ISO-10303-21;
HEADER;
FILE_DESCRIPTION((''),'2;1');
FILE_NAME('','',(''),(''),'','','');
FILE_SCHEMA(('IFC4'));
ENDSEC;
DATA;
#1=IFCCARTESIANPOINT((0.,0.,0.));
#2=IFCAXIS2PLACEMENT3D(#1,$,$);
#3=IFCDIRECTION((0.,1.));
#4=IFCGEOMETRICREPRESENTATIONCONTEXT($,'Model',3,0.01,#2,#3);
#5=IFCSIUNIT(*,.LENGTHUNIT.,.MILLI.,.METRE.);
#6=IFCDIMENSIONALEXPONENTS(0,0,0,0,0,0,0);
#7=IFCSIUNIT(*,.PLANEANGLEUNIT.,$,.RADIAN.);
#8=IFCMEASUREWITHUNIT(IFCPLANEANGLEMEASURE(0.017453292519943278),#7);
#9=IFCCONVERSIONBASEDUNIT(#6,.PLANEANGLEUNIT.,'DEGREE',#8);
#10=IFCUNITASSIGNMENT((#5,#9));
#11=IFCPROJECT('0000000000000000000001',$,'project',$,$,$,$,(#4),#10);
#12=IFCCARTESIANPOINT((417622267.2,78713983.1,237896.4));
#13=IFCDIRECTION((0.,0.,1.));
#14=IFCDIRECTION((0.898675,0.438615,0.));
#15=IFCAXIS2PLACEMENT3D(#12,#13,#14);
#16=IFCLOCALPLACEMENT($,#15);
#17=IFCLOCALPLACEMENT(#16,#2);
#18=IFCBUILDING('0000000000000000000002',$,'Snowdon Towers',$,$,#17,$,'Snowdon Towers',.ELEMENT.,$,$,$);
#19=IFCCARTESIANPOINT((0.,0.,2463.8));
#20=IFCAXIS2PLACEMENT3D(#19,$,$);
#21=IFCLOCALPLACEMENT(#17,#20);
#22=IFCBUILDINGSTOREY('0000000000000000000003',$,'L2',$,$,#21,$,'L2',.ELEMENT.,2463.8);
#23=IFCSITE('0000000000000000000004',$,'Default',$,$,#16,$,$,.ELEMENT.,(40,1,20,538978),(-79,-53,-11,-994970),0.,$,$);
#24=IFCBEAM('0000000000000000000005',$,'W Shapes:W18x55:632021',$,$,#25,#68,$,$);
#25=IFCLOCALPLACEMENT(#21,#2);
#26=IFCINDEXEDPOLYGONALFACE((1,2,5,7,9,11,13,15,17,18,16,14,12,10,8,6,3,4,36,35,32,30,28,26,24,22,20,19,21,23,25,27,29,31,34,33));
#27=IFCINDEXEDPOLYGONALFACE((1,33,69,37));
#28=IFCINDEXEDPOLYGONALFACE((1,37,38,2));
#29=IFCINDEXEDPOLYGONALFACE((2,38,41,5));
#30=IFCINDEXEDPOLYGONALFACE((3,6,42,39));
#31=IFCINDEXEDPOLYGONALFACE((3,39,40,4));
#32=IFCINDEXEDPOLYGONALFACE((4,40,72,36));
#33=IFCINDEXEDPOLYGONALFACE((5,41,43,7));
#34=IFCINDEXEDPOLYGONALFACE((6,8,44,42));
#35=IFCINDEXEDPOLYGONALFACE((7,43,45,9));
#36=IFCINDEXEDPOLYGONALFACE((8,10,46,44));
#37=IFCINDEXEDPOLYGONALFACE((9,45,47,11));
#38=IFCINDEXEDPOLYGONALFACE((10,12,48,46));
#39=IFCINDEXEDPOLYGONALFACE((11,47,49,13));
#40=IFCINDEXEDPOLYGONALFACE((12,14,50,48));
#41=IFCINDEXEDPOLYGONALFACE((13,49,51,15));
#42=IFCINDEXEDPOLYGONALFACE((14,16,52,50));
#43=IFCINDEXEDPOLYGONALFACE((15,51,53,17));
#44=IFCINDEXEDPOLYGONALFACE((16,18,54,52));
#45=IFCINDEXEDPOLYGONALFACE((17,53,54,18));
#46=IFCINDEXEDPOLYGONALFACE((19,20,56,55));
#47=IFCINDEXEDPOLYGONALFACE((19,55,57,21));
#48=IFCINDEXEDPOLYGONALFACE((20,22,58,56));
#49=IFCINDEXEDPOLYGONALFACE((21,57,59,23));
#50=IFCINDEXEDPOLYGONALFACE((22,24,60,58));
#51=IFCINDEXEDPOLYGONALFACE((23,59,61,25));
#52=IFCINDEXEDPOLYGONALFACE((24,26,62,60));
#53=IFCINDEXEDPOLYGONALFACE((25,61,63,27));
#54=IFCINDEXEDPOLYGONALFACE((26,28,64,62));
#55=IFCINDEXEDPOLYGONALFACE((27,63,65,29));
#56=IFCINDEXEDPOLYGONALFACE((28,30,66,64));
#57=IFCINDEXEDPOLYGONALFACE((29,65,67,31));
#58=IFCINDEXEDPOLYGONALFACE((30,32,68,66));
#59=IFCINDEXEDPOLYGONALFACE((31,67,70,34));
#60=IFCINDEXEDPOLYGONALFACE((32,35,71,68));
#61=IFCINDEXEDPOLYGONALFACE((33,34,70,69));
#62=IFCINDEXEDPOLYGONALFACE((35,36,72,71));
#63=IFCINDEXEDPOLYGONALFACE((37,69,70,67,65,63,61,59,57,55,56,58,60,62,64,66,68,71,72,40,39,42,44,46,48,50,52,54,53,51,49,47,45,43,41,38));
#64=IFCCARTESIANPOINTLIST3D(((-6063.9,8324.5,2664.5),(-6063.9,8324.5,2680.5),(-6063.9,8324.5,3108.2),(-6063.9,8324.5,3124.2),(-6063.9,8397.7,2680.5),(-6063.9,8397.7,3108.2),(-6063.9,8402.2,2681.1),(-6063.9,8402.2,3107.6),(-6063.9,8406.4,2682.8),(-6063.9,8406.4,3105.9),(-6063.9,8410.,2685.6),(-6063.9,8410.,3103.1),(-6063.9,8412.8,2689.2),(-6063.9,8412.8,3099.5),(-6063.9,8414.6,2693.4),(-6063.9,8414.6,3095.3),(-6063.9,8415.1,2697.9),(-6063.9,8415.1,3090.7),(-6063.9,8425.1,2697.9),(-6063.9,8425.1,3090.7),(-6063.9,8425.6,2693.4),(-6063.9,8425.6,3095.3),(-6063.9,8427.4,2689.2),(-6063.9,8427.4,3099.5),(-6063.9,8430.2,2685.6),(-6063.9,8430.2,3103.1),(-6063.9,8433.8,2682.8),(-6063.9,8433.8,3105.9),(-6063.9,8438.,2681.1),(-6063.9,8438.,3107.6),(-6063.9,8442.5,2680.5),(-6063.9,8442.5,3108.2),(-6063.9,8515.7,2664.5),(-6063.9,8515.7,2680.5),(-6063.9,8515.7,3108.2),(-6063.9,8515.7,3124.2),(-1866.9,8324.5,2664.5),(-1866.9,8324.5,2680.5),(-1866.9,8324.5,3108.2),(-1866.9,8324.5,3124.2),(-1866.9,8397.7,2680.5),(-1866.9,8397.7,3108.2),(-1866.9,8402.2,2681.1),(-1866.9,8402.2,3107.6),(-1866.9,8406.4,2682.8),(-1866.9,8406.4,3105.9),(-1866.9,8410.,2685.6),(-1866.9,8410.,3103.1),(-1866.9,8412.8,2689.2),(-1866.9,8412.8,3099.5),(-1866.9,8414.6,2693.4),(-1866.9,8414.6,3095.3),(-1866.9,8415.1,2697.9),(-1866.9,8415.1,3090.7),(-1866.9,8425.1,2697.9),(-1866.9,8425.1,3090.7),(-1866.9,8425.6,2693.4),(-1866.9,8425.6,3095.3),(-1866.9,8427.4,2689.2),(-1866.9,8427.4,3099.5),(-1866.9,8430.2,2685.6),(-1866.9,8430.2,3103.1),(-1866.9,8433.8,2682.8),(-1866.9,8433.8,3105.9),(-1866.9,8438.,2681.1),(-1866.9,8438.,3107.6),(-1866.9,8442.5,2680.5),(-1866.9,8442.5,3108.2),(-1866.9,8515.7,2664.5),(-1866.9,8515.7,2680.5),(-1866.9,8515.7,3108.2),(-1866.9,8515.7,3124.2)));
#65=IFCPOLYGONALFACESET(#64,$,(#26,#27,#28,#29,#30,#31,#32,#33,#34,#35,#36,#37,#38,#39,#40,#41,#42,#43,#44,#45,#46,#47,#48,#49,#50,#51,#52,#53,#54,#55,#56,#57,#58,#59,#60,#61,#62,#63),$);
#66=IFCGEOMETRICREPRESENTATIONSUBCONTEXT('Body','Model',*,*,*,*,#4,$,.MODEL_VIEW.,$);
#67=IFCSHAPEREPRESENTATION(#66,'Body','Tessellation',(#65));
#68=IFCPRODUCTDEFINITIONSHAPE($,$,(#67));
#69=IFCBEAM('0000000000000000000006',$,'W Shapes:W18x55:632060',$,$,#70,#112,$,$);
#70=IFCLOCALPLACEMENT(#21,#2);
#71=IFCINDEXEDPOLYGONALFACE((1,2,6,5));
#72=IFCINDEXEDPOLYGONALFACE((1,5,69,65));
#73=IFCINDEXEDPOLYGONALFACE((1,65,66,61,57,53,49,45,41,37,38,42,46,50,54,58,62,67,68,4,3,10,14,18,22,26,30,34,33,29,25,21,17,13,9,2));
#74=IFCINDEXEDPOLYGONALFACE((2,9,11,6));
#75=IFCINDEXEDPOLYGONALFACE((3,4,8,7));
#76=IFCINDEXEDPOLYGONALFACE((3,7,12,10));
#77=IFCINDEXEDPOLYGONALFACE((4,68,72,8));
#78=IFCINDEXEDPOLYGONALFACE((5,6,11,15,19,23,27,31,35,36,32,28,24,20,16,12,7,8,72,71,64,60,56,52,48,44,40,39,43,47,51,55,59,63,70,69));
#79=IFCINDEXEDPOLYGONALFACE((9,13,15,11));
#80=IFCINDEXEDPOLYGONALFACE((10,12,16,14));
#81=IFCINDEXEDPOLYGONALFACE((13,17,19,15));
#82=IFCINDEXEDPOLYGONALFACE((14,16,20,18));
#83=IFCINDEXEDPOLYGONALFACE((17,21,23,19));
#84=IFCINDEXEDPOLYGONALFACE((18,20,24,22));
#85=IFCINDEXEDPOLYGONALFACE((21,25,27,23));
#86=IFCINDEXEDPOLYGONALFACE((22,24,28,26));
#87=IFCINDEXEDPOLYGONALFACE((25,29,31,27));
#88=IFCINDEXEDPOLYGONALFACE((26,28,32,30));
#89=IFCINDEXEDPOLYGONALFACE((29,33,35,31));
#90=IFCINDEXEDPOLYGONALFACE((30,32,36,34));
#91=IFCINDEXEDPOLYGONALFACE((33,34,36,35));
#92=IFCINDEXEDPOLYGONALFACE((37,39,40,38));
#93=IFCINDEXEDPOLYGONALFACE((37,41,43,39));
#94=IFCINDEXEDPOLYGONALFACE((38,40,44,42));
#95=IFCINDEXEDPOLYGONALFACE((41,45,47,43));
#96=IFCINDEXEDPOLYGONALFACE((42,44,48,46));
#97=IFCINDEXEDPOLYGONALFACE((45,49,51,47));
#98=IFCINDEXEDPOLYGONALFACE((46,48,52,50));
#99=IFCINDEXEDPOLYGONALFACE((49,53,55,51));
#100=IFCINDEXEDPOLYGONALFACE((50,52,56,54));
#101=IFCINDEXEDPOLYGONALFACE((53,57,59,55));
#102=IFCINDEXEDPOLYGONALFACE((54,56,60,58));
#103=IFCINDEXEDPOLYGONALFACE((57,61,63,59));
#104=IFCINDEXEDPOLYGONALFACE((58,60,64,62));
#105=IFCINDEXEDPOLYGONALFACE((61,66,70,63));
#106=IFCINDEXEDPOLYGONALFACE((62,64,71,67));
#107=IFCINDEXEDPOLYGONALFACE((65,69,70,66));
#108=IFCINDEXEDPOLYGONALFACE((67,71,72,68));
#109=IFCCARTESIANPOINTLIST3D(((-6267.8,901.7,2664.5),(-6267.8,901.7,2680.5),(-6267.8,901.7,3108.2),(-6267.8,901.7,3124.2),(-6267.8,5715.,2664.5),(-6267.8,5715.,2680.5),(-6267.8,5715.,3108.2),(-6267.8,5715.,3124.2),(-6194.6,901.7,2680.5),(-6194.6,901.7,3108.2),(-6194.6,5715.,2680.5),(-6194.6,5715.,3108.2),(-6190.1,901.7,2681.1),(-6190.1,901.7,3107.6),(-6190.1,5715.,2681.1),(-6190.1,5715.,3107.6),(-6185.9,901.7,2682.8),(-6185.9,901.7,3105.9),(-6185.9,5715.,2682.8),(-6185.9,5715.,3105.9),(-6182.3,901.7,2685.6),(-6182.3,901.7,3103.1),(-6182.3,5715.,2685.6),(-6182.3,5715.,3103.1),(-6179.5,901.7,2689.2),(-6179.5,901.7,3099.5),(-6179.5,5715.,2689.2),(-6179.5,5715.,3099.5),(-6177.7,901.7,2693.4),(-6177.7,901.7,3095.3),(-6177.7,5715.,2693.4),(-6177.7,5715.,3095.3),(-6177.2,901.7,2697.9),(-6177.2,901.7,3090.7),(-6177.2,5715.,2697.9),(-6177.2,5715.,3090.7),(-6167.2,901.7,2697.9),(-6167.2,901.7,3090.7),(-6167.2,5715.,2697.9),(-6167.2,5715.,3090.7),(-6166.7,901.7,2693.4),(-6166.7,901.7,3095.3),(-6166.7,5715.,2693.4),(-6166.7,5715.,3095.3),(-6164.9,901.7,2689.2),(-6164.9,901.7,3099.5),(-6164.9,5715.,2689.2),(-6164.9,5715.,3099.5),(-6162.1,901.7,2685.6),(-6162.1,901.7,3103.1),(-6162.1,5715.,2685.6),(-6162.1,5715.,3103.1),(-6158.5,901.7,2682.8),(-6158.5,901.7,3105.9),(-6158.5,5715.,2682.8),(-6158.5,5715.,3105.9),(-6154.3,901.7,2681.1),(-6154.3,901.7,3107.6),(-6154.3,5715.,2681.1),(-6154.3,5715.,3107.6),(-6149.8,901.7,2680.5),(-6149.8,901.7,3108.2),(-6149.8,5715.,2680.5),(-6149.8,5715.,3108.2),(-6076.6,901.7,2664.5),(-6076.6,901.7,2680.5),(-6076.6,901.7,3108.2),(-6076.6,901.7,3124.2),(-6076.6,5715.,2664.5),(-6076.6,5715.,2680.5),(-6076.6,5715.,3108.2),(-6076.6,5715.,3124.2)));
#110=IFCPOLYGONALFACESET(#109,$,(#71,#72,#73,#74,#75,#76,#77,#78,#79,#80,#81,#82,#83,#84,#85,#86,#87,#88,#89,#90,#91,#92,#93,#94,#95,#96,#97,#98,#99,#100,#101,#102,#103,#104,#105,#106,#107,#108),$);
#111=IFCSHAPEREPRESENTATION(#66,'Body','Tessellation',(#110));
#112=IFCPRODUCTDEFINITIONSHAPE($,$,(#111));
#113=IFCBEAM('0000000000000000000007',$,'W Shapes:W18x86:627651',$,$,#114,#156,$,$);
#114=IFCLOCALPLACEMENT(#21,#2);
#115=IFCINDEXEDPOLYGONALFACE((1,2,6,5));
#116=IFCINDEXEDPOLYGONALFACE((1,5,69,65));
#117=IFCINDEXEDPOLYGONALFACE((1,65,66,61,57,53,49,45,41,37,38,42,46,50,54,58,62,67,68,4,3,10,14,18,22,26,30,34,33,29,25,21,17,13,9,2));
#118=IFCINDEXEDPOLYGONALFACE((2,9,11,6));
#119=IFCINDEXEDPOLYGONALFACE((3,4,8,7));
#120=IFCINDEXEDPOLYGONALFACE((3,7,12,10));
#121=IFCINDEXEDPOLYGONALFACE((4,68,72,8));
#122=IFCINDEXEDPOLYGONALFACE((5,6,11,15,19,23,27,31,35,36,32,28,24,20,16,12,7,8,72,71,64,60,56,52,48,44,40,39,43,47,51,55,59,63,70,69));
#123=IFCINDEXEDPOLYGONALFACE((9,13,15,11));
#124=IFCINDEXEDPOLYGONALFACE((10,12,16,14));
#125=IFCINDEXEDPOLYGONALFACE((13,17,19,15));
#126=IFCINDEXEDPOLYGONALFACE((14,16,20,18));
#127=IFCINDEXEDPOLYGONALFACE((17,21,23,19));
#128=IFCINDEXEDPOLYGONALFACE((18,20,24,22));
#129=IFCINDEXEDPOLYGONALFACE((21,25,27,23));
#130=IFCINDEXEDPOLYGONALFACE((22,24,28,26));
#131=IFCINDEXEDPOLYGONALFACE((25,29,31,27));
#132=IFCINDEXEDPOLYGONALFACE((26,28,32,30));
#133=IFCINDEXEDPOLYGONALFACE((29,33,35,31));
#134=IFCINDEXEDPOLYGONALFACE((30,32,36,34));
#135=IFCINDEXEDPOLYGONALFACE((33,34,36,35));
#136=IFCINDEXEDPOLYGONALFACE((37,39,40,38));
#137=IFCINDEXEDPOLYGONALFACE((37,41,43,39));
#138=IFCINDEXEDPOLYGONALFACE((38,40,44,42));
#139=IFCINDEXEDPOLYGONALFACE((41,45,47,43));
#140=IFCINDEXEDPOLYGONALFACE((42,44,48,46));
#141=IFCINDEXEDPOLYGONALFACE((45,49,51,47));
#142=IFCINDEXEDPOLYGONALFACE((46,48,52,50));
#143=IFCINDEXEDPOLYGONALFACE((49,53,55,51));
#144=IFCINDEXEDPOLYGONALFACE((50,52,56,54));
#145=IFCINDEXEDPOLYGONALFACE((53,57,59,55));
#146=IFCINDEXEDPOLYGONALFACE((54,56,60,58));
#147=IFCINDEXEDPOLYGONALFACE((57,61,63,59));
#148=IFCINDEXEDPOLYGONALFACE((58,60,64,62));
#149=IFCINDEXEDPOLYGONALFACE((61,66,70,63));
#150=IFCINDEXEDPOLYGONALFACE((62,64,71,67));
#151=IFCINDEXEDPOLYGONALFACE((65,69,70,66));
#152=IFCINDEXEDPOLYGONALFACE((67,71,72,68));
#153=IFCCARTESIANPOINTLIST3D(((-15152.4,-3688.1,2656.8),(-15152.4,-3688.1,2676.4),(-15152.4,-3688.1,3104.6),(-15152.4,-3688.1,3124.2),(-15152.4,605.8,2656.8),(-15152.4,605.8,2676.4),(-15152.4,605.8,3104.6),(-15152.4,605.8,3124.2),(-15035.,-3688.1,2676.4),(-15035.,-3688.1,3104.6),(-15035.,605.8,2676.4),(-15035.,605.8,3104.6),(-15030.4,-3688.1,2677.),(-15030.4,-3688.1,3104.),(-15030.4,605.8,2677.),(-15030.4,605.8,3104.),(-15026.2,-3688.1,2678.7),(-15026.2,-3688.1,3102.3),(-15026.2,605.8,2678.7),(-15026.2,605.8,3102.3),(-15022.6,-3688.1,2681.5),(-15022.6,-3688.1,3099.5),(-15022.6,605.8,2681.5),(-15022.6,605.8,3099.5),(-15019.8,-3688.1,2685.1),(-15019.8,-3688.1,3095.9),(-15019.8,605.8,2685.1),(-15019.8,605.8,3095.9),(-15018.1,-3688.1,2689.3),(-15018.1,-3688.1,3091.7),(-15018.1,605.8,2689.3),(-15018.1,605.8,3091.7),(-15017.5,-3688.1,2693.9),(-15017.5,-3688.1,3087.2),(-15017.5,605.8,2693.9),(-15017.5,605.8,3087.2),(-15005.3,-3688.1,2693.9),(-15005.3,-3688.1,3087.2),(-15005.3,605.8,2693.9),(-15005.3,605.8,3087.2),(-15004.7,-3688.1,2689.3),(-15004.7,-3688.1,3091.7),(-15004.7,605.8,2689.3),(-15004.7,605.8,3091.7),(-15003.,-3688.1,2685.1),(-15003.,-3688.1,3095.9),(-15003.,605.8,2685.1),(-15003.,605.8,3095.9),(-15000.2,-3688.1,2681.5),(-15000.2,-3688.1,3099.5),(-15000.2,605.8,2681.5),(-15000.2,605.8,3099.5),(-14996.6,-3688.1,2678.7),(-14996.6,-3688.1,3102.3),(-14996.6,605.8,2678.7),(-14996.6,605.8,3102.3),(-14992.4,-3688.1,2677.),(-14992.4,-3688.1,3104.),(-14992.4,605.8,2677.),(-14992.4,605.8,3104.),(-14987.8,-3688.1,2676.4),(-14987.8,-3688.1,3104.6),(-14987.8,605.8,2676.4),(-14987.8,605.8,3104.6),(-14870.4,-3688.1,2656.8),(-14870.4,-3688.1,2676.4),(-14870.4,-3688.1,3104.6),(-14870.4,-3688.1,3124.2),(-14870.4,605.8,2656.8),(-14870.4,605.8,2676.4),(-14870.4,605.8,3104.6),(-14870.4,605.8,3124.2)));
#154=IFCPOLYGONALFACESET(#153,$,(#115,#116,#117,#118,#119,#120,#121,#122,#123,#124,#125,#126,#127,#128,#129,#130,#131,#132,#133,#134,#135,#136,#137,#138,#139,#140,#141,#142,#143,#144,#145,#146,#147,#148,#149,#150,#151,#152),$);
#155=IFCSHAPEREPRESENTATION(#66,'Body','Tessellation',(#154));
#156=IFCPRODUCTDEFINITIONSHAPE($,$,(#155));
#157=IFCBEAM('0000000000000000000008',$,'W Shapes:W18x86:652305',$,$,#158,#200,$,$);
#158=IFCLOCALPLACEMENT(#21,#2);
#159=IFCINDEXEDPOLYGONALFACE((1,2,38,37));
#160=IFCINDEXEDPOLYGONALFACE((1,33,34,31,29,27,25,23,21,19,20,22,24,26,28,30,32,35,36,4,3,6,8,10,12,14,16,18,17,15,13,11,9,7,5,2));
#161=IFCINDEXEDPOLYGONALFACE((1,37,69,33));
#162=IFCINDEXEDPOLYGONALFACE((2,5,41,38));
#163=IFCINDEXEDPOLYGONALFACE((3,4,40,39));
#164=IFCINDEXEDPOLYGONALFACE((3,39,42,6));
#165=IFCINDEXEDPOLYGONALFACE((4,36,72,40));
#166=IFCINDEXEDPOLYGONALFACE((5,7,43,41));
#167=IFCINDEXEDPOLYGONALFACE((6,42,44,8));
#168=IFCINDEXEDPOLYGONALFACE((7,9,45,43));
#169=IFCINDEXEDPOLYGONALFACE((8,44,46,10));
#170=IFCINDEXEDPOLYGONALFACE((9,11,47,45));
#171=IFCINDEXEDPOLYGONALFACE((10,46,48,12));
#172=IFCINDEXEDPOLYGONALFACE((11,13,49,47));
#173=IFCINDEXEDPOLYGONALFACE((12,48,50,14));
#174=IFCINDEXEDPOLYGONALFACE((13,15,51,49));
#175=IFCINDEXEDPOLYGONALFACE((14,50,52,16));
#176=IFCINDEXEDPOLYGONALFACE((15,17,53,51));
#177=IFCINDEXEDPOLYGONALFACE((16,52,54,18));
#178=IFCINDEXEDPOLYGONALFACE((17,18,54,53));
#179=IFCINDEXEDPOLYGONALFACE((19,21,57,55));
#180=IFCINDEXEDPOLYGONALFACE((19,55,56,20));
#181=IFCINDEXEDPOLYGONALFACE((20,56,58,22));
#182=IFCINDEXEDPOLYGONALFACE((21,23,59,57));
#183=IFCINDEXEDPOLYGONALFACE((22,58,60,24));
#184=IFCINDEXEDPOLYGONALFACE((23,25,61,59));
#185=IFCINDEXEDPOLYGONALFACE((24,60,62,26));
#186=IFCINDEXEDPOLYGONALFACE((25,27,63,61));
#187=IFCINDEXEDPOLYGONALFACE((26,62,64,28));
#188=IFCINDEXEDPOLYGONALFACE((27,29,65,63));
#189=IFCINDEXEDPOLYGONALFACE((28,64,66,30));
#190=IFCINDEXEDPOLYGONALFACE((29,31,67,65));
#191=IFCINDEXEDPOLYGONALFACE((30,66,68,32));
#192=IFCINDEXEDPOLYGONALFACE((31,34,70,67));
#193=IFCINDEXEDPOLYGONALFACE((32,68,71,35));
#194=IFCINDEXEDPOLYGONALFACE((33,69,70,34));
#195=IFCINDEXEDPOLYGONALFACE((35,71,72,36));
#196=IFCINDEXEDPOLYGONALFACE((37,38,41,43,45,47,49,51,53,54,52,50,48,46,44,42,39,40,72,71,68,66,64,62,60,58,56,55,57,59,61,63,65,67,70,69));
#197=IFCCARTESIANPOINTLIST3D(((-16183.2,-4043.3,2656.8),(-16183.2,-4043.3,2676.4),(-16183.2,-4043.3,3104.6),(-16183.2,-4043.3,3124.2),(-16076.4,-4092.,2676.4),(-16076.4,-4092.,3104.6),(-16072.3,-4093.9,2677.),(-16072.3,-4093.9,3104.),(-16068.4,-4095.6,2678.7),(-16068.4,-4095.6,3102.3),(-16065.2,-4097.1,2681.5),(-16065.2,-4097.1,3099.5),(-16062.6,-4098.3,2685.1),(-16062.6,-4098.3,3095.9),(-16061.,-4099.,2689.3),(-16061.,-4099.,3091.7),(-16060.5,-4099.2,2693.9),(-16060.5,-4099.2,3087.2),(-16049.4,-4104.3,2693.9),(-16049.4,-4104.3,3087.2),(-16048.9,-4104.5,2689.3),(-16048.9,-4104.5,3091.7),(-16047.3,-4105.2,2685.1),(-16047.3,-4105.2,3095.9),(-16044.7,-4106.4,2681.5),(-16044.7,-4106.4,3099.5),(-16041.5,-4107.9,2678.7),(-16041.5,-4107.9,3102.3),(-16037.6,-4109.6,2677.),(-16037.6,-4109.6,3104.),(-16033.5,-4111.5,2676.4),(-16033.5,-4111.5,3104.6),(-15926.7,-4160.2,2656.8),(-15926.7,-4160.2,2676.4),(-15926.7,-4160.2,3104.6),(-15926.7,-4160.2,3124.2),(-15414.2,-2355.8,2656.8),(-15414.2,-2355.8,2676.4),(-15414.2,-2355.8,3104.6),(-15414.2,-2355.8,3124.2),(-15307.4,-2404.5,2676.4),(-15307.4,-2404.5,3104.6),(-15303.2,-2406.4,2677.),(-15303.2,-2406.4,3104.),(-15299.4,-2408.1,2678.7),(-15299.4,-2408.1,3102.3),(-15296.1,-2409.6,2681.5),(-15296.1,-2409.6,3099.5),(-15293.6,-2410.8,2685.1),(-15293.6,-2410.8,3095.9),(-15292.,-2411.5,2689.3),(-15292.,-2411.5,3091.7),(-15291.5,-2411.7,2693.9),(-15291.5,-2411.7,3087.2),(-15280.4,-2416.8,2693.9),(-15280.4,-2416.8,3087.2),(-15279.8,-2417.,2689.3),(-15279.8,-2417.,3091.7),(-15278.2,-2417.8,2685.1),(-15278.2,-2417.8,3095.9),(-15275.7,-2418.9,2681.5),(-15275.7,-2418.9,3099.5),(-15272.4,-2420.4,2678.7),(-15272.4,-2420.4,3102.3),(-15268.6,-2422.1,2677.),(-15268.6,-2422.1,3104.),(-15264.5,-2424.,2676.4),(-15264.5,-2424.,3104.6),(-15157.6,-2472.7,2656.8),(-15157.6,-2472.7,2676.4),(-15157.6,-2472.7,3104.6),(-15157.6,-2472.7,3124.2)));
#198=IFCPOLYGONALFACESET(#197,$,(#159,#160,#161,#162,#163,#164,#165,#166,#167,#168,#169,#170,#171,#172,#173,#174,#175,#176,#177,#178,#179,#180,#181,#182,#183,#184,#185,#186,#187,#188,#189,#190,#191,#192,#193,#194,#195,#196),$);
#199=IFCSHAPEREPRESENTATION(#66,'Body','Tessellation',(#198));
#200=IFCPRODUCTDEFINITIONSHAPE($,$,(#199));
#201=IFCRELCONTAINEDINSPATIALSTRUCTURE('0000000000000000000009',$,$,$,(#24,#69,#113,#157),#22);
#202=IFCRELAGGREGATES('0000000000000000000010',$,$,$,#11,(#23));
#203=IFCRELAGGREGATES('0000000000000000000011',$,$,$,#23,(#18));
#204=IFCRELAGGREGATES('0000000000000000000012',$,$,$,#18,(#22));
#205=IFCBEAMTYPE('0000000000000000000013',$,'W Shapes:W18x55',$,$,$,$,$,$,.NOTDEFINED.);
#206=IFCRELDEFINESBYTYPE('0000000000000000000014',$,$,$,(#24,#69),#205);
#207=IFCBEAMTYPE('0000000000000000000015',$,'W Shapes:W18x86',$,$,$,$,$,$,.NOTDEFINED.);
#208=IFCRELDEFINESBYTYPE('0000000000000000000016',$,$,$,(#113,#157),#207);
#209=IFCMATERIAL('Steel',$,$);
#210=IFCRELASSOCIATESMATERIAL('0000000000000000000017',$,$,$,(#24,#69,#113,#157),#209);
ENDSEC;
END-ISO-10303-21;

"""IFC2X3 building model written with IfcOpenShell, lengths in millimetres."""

from ifc_helpers import new_model, entity, si_unit, converted_unit, direction, frame, frame_2d, origin, place, context, subcontext, project, spatial, i_section, extrude, material, type_object, element, save


model = new_model("IFC2X3")

# Units and contexts
model_context = context("Model", 3, precision=0.01, world=origin(), true_north=direction((0.0, 1.0)))
body_context = subcontext(model_context, "Body", "Model", "MODEL_VIEW")
ifc_project = project(units=[si_unit("LENGTHUNIT", "METRE", prefix="MILLI"), converted_unit("PLANEANGLEUNIT", "DEGREE", entity("IfcPlaneAngleMeasure", 0.017453292519943278), si_unit("PLANEANGLEUNIT", "RADIAN"), dimensions=[0, 0, 0, 0, 0, 0, 0])], contexts=[model_context])

# Site, building, storey
site_placement = place(None, frame((417622267.2, 78713983.1, 237896.4), z_axis=(0.0, 0.0, 1.0), x_axis=(0.898675, 0.438615, 0.0)))
site = spatial("IfcSite", under=ifc_project, at=site_placement, Name="Default", CompositionType="ELEMENT", RefLatitude=(40, 1, 20, 538978), RefLongitude=(-79, -53, -11, -994970), RefElevation=0.0)
building_placement = place(site_placement, origin())
building = spatial("IfcBuilding", under=site, at=building_placement, Name="Snowdon Towers", LongName="Snowdon Towers", CompositionType="ELEMENT")
storey_placement = place(building_placement, frame((0.0, 0.0, 2463.8)))
storey = spatial("IfcBuildingStorey", under=building, at=storey_placement, Name="L2", LongName="L2", CompositionType="ELEMENT", Elevation=2463.8)

# Beams
ifc_material_1 = material(Name="Steel")
beam_type_1 = type_object("IfcBeamType", Name="W Shapes:W18x55", PredefinedType="NOTDEFINED")
beam_1_placement = place(storey_placement, frame((-1727.2, 8420.1, 3124.2), z_axis=(0.0, 0.0, 1.0), x_axis=(-1.0, 0.0, 0.0)))
element("IfcBeam", 1, at=beam_1_placement, inside=storey, type_object=beam_type_1, material=ifc_material_1, Name="W Shapes:W18x55:632021", context=body_context, shape_type="SweptSolid", body=[
    extrude(i_section(OverallWidth=191.3, OverallDepth=459.7, WebThickness=9.9, FlangeThickness=16.0, FilletRadius=17.5, at=frame_2d((0.0, 0.0), x_axis=(0.0, 1.0))), frame((139.7, 0.0, -229.9), z_axis=(1.0, 0.0, 0.0), x_axis=(0.0, 0.0, -1.0)), (0.0, 0.0, 1.0), 4197.0),
])
beam_2_placement = place(storey_placement, frame((-6172.2, 5854.7, 3124.2), z_axis=(0.0, 0.0, 1.0), x_axis=(0.0, -1.0, 0.0)))
element("IfcBeam", 2, at=beam_2_placement, inside=storey, type_object=beam_type_1, material=ifc_material_1, Name="W Shapes:W18x55:632060", context=body_context, shape_type="SweptSolid", body=[
    extrude(i_section(OverallWidth=191.3, OverallDepth=459.7, WebThickness=9.9, FlangeThickness=16.0, FilletRadius=17.5, at=frame_2d((0.0, 0.0), x_axis=(0.0, 1.0))), frame((139.7, 0.0, -229.9), z_axis=(1.0, 0.0, 0.0), x_axis=(0.0, 0.0, -1.0)), (0.0, 0.0, 1.0), 4813.3),
])
beam_type_2 = type_object("IfcBeamType", Name="W Shapes:W18x86", PredefinedType="NOTDEFINED")
beam_3_placement = place(storey_placement, frame((-15011.4, 762.0, 3124.2), z_axis=(0.0, 0.0, 1.0), x_axis=(0.0, -1.0, 0.0)))
element("IfcBeam", 3, at=beam_3_placement, inside=storey, type_object=beam_type_2, material=ifc_material_1, Name="W Shapes:W18x86:627651", context=body_context, shape_type="SweptSolid", body=[
    extrude(i_section(OverallWidth=281.9, OverallDepth=467.4, WebThickness=12.2, FlangeThickness=19.6, FilletRadius=17.5, at=frame_2d((0.0, 0.0), x_axis=(0.0, 1.0))), frame((156.2, 0.0, -233.7), z_axis=(1.0, 0.0, 0.0), x_axis=(0.0, 0.0, -1.0)), (0.0, 0.0, 1.0), 4293.9),
])
beam_4_placement = place(storey_placement, frame((-16118.7, -4241.6, 3124.2), z_axis=(0.0, 0.0, 1.0), x_axis=(0.414693, 0.909961, 0.0)))
element("IfcBeam", 4, at=beam_4_placement, inside=storey, type_object=beam_type_2, material=ifc_material_1, Name="W Shapes:W18x86:652305", context=body_context, shape_type="SweptSolid", body=[
    extrude(i_section(OverallWidth=281.9, OverallDepth=467.4, WebThickness=12.2, FlangeThickness=19.6, FilletRadius=17.5, at=frame_2d((0.0, 0.0), x_axis=(0.0, 1.0))), frame((153.7, 0.0, -233.7), z_axis=(1.0, 0.0, 0.0), x_axis=(0.0, 0.0, -1.0)), (0.0, 0.0, 1.0), 1854.5),
])

save(model, "model.ifc")
